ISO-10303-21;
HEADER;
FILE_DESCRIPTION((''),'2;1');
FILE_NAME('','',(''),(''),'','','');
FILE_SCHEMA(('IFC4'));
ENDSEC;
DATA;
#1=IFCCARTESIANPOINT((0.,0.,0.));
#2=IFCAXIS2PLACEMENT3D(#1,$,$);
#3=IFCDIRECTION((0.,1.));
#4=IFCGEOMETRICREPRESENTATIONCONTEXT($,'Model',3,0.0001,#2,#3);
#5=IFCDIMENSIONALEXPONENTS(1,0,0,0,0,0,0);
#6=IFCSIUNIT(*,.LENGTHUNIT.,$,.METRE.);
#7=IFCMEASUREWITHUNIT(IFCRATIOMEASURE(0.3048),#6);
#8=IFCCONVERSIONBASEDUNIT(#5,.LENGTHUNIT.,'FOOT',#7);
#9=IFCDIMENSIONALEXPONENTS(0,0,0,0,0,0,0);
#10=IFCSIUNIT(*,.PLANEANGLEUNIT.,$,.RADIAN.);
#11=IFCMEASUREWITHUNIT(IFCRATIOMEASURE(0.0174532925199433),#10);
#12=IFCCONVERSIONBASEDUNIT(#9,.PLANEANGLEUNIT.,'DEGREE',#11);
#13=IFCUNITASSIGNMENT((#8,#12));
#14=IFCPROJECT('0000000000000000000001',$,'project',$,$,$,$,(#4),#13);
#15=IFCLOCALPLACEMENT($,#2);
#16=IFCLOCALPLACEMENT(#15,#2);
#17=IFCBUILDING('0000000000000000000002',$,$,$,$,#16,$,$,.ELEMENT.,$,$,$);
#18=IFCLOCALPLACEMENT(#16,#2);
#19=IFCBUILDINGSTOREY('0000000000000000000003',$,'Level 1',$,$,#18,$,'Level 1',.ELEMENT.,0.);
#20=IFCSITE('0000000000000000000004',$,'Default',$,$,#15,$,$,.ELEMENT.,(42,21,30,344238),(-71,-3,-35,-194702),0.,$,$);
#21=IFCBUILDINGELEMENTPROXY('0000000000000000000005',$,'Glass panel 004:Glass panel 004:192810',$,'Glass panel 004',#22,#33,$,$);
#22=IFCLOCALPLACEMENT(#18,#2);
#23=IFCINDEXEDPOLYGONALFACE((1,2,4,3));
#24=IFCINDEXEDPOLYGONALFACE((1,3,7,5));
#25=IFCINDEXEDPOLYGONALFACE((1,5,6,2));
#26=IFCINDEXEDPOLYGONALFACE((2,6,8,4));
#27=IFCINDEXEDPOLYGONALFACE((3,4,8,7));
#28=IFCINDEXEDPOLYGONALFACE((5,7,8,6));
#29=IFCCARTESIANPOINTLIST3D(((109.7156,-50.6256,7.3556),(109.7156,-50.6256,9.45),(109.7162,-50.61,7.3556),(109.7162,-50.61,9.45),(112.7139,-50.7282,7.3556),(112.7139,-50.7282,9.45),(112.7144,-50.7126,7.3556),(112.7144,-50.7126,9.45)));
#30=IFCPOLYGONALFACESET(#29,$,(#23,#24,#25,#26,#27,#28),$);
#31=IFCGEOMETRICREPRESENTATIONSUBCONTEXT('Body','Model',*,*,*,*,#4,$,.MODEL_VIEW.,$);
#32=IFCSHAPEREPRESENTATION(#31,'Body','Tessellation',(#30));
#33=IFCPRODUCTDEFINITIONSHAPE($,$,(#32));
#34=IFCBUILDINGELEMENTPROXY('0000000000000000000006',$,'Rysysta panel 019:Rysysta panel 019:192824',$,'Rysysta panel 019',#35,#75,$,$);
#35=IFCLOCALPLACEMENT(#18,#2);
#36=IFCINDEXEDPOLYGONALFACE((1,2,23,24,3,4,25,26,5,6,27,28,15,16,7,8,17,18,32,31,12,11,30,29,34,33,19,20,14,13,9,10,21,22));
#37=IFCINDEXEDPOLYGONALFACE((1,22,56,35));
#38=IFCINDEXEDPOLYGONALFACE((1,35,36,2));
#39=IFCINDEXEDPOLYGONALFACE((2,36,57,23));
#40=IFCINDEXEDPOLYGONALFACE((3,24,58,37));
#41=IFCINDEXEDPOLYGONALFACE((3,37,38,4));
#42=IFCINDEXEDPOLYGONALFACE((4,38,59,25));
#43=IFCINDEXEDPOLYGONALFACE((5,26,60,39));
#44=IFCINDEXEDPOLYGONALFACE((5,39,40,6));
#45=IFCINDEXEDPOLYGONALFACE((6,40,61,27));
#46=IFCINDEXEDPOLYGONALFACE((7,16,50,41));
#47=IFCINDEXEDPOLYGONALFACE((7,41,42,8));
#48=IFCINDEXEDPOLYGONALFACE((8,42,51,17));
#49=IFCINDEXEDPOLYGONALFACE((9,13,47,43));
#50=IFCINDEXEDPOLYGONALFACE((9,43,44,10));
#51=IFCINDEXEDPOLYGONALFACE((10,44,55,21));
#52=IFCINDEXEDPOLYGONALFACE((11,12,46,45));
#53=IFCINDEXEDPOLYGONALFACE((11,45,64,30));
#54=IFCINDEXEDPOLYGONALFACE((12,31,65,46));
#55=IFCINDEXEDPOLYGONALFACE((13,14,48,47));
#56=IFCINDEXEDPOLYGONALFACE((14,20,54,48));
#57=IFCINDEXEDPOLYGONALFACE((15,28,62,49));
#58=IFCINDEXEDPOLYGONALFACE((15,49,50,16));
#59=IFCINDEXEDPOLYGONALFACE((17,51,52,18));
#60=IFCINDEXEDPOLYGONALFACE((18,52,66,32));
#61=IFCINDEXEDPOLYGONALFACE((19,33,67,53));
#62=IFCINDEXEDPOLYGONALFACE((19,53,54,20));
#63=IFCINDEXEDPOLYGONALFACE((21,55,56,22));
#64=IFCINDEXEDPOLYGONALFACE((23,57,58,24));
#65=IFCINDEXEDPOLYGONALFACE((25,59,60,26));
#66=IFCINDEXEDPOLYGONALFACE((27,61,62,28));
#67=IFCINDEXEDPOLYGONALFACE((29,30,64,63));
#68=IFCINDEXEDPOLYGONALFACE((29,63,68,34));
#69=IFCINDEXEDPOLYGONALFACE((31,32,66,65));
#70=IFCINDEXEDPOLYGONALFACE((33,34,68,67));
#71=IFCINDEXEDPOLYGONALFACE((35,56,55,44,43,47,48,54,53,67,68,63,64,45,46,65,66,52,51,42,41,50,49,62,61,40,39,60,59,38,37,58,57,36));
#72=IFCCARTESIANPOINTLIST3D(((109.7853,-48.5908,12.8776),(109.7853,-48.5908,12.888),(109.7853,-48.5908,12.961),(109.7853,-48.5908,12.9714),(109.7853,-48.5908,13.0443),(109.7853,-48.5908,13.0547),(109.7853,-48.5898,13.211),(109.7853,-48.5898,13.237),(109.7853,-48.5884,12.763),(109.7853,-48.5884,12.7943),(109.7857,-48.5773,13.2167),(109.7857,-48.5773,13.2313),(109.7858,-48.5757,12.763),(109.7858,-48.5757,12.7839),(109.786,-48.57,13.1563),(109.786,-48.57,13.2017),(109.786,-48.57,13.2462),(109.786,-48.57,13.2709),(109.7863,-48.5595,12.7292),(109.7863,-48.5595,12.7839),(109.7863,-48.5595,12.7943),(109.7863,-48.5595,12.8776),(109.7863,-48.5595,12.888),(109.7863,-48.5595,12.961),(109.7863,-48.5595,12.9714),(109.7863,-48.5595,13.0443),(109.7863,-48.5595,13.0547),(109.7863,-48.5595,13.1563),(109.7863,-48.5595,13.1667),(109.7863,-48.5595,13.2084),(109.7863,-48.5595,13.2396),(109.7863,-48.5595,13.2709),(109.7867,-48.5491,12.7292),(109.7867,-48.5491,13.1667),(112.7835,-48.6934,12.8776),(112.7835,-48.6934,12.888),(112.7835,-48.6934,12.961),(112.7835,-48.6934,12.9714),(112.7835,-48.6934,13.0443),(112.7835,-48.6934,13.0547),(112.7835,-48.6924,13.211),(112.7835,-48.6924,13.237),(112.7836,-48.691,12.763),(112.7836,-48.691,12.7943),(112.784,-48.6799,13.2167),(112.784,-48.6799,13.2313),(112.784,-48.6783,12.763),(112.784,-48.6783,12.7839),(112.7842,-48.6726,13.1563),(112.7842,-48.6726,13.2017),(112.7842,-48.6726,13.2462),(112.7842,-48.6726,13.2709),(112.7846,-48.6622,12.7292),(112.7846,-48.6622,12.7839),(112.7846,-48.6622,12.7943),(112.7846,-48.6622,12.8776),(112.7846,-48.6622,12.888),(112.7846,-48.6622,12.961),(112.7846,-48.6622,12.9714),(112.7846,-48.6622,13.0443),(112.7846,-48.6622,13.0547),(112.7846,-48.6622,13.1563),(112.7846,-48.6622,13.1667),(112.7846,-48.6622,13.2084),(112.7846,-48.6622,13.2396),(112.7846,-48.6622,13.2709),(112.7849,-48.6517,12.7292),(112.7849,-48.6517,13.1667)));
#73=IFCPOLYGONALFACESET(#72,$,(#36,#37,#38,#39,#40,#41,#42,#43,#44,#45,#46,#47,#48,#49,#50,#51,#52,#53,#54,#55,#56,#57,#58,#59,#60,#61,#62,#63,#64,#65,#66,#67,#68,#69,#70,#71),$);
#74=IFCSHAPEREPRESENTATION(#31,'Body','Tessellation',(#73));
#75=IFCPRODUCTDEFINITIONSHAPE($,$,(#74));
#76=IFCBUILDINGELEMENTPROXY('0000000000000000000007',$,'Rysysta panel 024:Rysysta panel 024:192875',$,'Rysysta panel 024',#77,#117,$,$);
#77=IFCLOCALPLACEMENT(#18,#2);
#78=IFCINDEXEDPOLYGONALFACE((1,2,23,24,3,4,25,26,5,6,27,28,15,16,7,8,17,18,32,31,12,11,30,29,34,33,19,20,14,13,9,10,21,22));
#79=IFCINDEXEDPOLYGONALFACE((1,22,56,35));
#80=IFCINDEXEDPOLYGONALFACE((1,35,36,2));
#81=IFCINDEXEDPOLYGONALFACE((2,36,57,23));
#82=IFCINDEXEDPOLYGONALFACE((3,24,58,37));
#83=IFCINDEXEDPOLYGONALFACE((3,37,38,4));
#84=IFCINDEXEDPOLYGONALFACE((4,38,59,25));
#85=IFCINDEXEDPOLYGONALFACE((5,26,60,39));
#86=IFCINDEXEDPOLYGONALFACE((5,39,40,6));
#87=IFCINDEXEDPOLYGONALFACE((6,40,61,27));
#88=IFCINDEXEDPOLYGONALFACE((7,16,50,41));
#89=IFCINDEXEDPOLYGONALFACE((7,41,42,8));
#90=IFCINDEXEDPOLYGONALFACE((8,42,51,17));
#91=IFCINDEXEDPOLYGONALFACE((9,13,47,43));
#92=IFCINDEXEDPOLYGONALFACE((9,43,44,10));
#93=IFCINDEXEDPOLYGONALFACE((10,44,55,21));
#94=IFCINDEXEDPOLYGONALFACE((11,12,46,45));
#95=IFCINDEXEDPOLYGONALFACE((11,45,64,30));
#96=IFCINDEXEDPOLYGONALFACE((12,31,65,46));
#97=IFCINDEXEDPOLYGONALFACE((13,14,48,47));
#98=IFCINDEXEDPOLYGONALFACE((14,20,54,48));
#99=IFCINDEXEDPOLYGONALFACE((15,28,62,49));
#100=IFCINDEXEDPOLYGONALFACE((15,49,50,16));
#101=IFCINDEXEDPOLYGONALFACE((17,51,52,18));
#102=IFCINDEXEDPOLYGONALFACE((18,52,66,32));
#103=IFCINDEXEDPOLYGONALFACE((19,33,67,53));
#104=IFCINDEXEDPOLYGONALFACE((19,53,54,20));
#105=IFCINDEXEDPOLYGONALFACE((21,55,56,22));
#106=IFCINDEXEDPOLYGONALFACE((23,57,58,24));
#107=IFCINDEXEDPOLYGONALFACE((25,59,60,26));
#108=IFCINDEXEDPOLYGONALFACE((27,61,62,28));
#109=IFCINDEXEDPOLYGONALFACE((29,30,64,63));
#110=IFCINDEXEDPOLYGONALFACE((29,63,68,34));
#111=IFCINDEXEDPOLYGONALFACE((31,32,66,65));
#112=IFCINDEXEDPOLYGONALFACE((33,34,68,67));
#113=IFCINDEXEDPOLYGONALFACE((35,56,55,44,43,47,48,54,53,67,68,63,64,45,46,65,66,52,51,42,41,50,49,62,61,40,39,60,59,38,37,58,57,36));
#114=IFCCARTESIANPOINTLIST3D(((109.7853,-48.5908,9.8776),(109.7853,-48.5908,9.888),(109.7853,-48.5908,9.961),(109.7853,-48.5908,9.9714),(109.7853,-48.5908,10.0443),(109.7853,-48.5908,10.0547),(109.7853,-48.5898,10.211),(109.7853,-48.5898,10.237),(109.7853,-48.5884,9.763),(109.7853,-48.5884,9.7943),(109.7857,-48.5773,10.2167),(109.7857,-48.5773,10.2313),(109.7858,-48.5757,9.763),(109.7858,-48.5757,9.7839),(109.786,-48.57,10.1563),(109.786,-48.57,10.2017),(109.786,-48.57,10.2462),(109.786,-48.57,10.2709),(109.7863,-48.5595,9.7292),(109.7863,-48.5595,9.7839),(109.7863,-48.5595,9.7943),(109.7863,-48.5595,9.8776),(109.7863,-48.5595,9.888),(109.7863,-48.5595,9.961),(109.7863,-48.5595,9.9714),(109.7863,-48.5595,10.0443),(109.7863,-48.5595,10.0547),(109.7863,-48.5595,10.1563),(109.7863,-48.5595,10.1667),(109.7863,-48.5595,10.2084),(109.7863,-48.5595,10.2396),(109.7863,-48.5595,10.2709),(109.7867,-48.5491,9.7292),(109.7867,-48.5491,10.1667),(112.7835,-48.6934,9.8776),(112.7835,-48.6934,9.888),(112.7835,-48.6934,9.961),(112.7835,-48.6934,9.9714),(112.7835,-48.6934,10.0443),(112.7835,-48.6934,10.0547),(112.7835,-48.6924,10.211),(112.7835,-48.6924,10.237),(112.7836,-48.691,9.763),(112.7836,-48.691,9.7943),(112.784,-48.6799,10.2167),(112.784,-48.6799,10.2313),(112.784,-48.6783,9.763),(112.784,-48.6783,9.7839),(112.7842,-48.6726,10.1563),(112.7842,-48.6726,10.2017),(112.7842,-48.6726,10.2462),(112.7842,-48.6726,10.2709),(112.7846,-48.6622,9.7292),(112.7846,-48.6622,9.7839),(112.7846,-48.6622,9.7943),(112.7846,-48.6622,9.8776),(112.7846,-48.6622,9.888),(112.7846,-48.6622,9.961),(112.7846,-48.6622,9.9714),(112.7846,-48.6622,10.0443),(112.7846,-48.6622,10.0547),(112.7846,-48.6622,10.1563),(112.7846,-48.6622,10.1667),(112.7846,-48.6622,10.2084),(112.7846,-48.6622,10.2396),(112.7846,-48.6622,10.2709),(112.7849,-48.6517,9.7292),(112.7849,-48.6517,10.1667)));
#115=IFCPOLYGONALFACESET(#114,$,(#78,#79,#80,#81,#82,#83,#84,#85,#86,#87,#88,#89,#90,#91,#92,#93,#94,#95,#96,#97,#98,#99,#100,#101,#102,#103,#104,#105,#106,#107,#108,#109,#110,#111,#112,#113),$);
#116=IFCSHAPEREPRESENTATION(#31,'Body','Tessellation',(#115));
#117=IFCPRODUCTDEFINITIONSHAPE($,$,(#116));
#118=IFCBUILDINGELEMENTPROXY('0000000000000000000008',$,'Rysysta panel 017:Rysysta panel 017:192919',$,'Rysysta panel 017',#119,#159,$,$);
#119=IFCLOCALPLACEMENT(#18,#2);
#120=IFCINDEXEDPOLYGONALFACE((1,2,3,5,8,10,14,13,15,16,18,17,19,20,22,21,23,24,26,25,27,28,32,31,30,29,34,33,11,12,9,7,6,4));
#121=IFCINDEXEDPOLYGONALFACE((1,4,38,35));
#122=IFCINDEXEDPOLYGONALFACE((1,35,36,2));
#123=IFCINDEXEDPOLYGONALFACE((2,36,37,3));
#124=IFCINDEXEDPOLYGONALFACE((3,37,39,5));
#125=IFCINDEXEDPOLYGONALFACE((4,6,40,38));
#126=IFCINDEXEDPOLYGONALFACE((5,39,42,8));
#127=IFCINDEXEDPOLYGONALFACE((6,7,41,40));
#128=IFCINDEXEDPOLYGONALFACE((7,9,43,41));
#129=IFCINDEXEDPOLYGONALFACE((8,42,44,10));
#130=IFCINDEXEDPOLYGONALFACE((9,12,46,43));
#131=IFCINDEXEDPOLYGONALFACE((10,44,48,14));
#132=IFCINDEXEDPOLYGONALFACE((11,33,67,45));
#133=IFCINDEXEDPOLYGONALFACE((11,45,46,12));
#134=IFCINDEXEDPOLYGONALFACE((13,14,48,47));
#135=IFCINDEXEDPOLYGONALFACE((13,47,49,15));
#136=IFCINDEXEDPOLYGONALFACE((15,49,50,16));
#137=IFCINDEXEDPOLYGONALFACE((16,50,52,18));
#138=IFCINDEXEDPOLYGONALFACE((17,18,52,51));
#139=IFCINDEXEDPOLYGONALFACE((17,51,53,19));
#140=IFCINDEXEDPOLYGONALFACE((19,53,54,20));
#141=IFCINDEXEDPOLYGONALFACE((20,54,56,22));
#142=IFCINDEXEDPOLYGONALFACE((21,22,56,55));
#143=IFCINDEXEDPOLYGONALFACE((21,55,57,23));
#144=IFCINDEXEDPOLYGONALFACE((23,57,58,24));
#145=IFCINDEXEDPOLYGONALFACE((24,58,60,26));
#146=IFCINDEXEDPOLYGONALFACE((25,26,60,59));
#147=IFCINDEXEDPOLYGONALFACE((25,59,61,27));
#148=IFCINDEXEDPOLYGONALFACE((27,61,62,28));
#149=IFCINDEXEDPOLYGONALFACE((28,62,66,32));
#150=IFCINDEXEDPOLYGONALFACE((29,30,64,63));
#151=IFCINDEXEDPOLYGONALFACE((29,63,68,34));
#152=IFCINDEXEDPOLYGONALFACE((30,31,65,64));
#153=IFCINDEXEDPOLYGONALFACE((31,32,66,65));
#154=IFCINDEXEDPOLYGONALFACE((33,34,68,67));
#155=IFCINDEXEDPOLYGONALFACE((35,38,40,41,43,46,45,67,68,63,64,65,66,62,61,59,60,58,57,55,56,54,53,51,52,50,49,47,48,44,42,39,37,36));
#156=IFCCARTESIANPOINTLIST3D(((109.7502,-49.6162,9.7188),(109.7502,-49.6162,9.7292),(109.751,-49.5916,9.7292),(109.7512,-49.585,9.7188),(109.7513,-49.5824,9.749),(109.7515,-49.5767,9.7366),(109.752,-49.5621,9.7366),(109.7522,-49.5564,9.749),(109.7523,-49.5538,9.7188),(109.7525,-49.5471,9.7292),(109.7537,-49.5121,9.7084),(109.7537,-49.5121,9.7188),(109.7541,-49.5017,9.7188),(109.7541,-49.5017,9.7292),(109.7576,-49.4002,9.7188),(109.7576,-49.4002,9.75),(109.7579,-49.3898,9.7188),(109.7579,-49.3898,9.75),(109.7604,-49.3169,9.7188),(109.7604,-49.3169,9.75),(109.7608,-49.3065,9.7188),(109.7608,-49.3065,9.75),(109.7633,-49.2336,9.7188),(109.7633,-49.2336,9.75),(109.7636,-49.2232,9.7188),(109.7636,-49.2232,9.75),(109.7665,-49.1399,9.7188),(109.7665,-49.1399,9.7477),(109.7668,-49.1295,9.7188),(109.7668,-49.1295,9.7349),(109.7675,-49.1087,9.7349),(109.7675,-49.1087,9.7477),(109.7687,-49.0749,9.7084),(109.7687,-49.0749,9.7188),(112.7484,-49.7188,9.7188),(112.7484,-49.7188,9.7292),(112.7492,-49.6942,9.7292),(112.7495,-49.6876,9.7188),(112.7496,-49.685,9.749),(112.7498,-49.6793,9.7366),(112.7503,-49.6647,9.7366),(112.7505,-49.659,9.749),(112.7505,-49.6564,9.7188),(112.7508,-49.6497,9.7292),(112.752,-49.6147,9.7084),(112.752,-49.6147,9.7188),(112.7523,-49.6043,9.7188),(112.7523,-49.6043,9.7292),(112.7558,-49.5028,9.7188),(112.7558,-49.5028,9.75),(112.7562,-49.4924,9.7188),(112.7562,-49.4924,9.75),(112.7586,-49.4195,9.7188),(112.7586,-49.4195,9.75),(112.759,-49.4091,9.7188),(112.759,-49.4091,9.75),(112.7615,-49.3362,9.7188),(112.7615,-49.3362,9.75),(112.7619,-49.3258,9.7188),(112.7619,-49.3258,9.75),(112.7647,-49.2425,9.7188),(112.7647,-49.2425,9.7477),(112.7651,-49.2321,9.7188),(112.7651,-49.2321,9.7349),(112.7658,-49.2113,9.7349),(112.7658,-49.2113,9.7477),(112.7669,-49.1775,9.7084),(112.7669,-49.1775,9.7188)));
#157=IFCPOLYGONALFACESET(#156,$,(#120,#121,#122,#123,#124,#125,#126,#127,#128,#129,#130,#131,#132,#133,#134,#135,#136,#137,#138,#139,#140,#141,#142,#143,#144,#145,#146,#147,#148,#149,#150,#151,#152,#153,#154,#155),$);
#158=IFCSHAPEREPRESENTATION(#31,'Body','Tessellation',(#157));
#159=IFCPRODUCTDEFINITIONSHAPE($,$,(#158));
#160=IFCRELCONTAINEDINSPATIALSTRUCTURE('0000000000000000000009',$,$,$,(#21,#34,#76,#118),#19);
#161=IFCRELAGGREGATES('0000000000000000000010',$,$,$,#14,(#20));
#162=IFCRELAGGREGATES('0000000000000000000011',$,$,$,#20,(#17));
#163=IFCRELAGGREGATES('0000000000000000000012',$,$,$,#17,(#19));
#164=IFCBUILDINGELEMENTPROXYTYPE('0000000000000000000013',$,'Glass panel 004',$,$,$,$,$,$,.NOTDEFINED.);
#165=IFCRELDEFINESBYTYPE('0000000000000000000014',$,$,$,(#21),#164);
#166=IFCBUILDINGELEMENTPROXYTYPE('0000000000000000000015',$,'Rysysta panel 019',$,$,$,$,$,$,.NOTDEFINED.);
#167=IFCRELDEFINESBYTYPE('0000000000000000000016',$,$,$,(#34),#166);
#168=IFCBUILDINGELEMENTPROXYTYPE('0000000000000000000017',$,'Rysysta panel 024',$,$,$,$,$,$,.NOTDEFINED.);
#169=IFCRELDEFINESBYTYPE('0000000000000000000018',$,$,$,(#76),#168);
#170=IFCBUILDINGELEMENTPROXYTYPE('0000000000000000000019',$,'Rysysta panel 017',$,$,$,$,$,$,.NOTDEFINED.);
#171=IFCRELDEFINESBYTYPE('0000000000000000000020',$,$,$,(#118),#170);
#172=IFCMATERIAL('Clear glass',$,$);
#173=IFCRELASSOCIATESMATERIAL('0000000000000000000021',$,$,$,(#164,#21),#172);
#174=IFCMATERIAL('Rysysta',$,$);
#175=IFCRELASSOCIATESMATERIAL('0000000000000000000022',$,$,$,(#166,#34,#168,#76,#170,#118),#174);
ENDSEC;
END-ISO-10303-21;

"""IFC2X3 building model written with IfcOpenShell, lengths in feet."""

from ifc_helpers import new_model, entity, si_unit, converted_unit, direction, frame, frame_2d, origin, place, context, subcontext, project, spatial, polyline, rectangle, outline, extrude, source, transform, mapped, material, type_object, type_shapes, element, save


model = new_model("IFC2X3")

# Units and contexts
model_context = context("Model", 3, precision=0.0001, world=origin(), true_north=direction((0.0, 1.0)))
body_context = subcontext(model_context, "Body", "Model", "MODEL_VIEW")
ifc_project = project(units=[converted_unit("LENGTHUNIT", "FOOT", entity("IfcRatioMeasure", 0.3048), si_unit("LENGTHUNIT", "METRE"), dimensions=[1, 0, 0, 0, 0, 0, 0]), converted_unit("PLANEANGLEUNIT", "DEGREE", entity("IfcRatioMeasure", 0.0174532925199433), si_unit("PLANEANGLEUNIT", "RADIAN"), dimensions=[0, 0, 0, 0, 0, 0, 0])], contexts=[model_context])

# Site, building, storey
site_placement = place(None, origin())
site = spatial("IfcSite", under=ifc_project, at=site_placement, Name="Default", CompositionType="ELEMENT", RefLatitude=(42, 21, 30, 344238), RefLongitude=(-71, -3, -35, -194702), RefElevation=0.0)
building_placement = place(site_placement, origin())
building = spatial("IfcBuilding", under=site, at=building_placement, CompositionType="ELEMENT")
storey_placement = place(building_placement, origin())
storey = spatial("IfcBuildingStorey", under=building, at=storey_placement, Name="Level 1", LongName="Level 1", CompositionType="ELEMENT", Elevation=0.0)

# Building element proxies
ifc_material_1 = material(Name="Rysysta")
ifc_material_2 = material(Name="Clear glass")
building_element_proxy_type_1 = type_object("IfcBuildingElementProxyType", Name="Glass panel 004", PredefinedType="NOTDEFINED", material=ifc_material_2)
shared_shape_1 = source(origin(), body_context, "Body", "SweptSolid", [
    extrude(rectangle(XDim=3.0, YDim=0.0156, at=frame_2d((0.0, 0.0), x_axis=(1.0, 0.0))), frame((111.215, -50.6691, 7.3556), z_axis=(0.0, 0.0, 1.0), x_axis=(-0.999415, 0.034202, 0.0)), (0.0, 0.0, 1.0), 2.0943),
])
type_shapes(building_element_proxy_type_1, [shared_shape_1])
proxy_1_placement = place(storey_placement, origin())
element("IfcBuildingElementProxy", 1, at=proxy_1_placement, inside=storey, type_object=building_element_proxy_type_1, material=ifc_material_2, Name="Glass panel 004:Glass panel 004:192810", ObjectType="Glass panel 004", context=body_context, shape_type="MappedRepresentation", body=[
    mapped(shared_shape_1, transform((0.0, 0.0, 0.0), scale=1.0)),
])
building_element_proxy_type_2 = type_object("IfcBuildingElementProxyType", Name="Rysysta panel 019", PredefinedType="NOTDEFINED", material=ifc_material_1)
shared_shape_2 = source(origin(), body_context, "Body", "SweptSolid", [
    extrude(outline(polyline([(-0.022, 0.1457), (-0.022, -0.2918), (-0.0116, -0.2918), (-0.0116, -0.2371), (0.0045, -0.2371), (0.0045, -0.258), (0.0173, -0.258), (0.0173, -0.2267), (-0.0116, -0.2267), (-0.0116, -0.1434), (0.0196, -0.1434), (0.0196, -0.133), (-0.0116, -0.133), (-0.0116, -0.06), (0.0196, -0.06), (0.0196, -0.0496), (-0.0116, -0.0496), (-0.0116, 0.0233), (0.0196, 0.0233), (0.0196, 0.0337), (-0.0116, 0.0337), (-0.0116, 0.1353), (-0.0012, 0.1353), (-0.0012, 0.1807), (0.0186, 0.1899), (0.0186, 0.216), (-0.0012, 0.2252), (-0.0012, 0.2498), (-0.0116, 0.2498), (-0.0116, 0.2186), (0.0062, 0.2103), (0.0062, 0.1956), (-0.0116, 0.1873), (-0.0116, 0.1457), (-0.022, 0.1457)])), frame((109.7859, -48.5711, 13.021), z_axis=(-0.999415, 0.034202, 0.0), x_axis=(-0.034202, -0.999415, 0.0)), (0.0, 0.0, -1.0), 3.0),
])
type_shapes(building_element_proxy_type_2, [shared_shape_2])
proxy_2_placement = place(storey_placement, origin())
element("IfcBuildingElementProxy", 2, at=proxy_2_placement, inside=storey, type_object=building_element_proxy_type_2, material=ifc_material_1, Name="Rysysta panel 019:Rysysta panel 019:192824", ObjectType="Rysysta panel 019", context=body_context, shape_type="MappedRepresentation", body=[
    mapped(shared_shape_2, transform((0.0, 0.0, 0.0), scale=1.0)),
])
building_element_proxy_type_3 = type_object("IfcBuildingElementProxyType", Name="Rysysta panel 024", PredefinedType="NOTDEFINED", material=ifc_material_1)
shared_shape_3 = source(origin(), body_context, "Body", "SweptSolid", [
    extrude(outline(polyline([(-0.022, 0.1457), (-0.022, -0.2918), (-0.0116, -0.2918), (-0.0116, -0.2371), (0.0045, -0.2371), (0.0045, -0.258), (0.0173, -0.258), (0.0173, -0.2267), (-0.0116, -0.2267), (-0.0116, -0.1434), (0.0196, -0.1434), (0.0196, -0.133), (-0.0116, -0.133), (-0.0116, -0.06), (0.0196, -0.06), (0.0196, -0.0496), (-0.0116, -0.0496), (-0.0116, 0.0233), (0.0196, 0.0233), (0.0196, 0.0337), (-0.0116, 0.0337), (-0.0116, 0.1353), (-0.0012, 0.1353), (-0.0012, 0.1807), (0.0186, 0.1899), (0.0186, 0.216), (-0.0012, 0.2252), (-0.0012, 0.2498), (-0.0116, 0.2498), (-0.0116, 0.2186), (0.0062, 0.2103), (0.0062, 0.1956), (-0.0116, 0.1873), (-0.0116, 0.1457), (-0.022, 0.1457)])), frame((109.7859, -48.5711, 10.021), z_axis=(-0.999415, 0.034202, 0.0), x_axis=(-0.034202, -0.999415, 0.0)), (0.0, 0.0, -1.0), 3.0),
])
type_shapes(building_element_proxy_type_3, [shared_shape_3])
proxy_3_placement = place(storey_placement, origin())
element("IfcBuildingElementProxy", 3, at=proxy_3_placement, inside=storey, type_object=building_element_proxy_type_3, material=ifc_material_1, Name="Rysysta panel 024:Rysysta panel 024:192875", ObjectType="Rysysta panel 024", context=body_context, shape_type="MappedRepresentation", body=[
    mapped(shared_shape_3, transform((0.0, 0.0, 0.0), scale=1.0)),
])
building_element_proxy_type_4 = type_object("IfcBuildingElementProxyType", Name="Rysysta panel 017", PredefinedType="NOTDEFINED", material=ifc_material_1)
shared_shape_4 = source(origin(), body_context, "Body", "SweptSolid", [
    extrude(outline(polyline([(-0.2918, -0.0116), (-0.2918, -0.022), (0.1457, -0.022), (0.1457, -0.0116), (0.1873, -0.0116), (0.1956, 0.0062), (0.2103, 0.0062), (0.2186, -0.0116), (0.2498, -0.0116), (0.2498, -0.0012), (0.2252, -0.0012), (0.216, 0.0186), (0.1899, 0.0186), (0.1807, -0.0012), (0.1353, -0.0012), (0.1353, -0.0116), (0.0337, -0.0116), (0.0337, 0.0196), (0.0233, 0.0196), (0.0233, -0.0116), (-0.0496, -0.0116), (-0.0496, 0.0196), (-0.06, 0.0196), (-0.06, -0.0116), (-0.133, -0.0116), (-0.133, 0.0196), (-0.1434, 0.0196), (-0.1434, -0.0116), (-0.2267, -0.0116), (-0.2267, 0.0173), (-0.258, 0.0173), (-0.258, 0.0045), (-0.2371, 0.0045), (-0.2371, -0.0116), (-0.2918, -0.0116)])), frame((109.7587, -49.3665, 9.7304), z_axis=(-0.999415, 0.034202, 0.0), x_axis=(-0.034202, -0.999415, 0.0)), (0.0, 0.0, -1.0), 3.0),
])
type_shapes(building_element_proxy_type_4, [shared_shape_4])
proxy_4_placement = place(storey_placement, origin())
element("IfcBuildingElementProxy", 4, at=proxy_4_placement, inside=storey, type_object=building_element_proxy_type_4, material=ifc_material_1, Name="Rysysta panel 017:Rysysta panel 017:192919", ObjectType="Rysysta panel 017", context=body_context, shape_type="MappedRepresentation", body=[
    mapped(shared_shape_4, transform((0.0, 0.0, 0.0), scale=1.0)),
])

save(model, "model.ifc")
